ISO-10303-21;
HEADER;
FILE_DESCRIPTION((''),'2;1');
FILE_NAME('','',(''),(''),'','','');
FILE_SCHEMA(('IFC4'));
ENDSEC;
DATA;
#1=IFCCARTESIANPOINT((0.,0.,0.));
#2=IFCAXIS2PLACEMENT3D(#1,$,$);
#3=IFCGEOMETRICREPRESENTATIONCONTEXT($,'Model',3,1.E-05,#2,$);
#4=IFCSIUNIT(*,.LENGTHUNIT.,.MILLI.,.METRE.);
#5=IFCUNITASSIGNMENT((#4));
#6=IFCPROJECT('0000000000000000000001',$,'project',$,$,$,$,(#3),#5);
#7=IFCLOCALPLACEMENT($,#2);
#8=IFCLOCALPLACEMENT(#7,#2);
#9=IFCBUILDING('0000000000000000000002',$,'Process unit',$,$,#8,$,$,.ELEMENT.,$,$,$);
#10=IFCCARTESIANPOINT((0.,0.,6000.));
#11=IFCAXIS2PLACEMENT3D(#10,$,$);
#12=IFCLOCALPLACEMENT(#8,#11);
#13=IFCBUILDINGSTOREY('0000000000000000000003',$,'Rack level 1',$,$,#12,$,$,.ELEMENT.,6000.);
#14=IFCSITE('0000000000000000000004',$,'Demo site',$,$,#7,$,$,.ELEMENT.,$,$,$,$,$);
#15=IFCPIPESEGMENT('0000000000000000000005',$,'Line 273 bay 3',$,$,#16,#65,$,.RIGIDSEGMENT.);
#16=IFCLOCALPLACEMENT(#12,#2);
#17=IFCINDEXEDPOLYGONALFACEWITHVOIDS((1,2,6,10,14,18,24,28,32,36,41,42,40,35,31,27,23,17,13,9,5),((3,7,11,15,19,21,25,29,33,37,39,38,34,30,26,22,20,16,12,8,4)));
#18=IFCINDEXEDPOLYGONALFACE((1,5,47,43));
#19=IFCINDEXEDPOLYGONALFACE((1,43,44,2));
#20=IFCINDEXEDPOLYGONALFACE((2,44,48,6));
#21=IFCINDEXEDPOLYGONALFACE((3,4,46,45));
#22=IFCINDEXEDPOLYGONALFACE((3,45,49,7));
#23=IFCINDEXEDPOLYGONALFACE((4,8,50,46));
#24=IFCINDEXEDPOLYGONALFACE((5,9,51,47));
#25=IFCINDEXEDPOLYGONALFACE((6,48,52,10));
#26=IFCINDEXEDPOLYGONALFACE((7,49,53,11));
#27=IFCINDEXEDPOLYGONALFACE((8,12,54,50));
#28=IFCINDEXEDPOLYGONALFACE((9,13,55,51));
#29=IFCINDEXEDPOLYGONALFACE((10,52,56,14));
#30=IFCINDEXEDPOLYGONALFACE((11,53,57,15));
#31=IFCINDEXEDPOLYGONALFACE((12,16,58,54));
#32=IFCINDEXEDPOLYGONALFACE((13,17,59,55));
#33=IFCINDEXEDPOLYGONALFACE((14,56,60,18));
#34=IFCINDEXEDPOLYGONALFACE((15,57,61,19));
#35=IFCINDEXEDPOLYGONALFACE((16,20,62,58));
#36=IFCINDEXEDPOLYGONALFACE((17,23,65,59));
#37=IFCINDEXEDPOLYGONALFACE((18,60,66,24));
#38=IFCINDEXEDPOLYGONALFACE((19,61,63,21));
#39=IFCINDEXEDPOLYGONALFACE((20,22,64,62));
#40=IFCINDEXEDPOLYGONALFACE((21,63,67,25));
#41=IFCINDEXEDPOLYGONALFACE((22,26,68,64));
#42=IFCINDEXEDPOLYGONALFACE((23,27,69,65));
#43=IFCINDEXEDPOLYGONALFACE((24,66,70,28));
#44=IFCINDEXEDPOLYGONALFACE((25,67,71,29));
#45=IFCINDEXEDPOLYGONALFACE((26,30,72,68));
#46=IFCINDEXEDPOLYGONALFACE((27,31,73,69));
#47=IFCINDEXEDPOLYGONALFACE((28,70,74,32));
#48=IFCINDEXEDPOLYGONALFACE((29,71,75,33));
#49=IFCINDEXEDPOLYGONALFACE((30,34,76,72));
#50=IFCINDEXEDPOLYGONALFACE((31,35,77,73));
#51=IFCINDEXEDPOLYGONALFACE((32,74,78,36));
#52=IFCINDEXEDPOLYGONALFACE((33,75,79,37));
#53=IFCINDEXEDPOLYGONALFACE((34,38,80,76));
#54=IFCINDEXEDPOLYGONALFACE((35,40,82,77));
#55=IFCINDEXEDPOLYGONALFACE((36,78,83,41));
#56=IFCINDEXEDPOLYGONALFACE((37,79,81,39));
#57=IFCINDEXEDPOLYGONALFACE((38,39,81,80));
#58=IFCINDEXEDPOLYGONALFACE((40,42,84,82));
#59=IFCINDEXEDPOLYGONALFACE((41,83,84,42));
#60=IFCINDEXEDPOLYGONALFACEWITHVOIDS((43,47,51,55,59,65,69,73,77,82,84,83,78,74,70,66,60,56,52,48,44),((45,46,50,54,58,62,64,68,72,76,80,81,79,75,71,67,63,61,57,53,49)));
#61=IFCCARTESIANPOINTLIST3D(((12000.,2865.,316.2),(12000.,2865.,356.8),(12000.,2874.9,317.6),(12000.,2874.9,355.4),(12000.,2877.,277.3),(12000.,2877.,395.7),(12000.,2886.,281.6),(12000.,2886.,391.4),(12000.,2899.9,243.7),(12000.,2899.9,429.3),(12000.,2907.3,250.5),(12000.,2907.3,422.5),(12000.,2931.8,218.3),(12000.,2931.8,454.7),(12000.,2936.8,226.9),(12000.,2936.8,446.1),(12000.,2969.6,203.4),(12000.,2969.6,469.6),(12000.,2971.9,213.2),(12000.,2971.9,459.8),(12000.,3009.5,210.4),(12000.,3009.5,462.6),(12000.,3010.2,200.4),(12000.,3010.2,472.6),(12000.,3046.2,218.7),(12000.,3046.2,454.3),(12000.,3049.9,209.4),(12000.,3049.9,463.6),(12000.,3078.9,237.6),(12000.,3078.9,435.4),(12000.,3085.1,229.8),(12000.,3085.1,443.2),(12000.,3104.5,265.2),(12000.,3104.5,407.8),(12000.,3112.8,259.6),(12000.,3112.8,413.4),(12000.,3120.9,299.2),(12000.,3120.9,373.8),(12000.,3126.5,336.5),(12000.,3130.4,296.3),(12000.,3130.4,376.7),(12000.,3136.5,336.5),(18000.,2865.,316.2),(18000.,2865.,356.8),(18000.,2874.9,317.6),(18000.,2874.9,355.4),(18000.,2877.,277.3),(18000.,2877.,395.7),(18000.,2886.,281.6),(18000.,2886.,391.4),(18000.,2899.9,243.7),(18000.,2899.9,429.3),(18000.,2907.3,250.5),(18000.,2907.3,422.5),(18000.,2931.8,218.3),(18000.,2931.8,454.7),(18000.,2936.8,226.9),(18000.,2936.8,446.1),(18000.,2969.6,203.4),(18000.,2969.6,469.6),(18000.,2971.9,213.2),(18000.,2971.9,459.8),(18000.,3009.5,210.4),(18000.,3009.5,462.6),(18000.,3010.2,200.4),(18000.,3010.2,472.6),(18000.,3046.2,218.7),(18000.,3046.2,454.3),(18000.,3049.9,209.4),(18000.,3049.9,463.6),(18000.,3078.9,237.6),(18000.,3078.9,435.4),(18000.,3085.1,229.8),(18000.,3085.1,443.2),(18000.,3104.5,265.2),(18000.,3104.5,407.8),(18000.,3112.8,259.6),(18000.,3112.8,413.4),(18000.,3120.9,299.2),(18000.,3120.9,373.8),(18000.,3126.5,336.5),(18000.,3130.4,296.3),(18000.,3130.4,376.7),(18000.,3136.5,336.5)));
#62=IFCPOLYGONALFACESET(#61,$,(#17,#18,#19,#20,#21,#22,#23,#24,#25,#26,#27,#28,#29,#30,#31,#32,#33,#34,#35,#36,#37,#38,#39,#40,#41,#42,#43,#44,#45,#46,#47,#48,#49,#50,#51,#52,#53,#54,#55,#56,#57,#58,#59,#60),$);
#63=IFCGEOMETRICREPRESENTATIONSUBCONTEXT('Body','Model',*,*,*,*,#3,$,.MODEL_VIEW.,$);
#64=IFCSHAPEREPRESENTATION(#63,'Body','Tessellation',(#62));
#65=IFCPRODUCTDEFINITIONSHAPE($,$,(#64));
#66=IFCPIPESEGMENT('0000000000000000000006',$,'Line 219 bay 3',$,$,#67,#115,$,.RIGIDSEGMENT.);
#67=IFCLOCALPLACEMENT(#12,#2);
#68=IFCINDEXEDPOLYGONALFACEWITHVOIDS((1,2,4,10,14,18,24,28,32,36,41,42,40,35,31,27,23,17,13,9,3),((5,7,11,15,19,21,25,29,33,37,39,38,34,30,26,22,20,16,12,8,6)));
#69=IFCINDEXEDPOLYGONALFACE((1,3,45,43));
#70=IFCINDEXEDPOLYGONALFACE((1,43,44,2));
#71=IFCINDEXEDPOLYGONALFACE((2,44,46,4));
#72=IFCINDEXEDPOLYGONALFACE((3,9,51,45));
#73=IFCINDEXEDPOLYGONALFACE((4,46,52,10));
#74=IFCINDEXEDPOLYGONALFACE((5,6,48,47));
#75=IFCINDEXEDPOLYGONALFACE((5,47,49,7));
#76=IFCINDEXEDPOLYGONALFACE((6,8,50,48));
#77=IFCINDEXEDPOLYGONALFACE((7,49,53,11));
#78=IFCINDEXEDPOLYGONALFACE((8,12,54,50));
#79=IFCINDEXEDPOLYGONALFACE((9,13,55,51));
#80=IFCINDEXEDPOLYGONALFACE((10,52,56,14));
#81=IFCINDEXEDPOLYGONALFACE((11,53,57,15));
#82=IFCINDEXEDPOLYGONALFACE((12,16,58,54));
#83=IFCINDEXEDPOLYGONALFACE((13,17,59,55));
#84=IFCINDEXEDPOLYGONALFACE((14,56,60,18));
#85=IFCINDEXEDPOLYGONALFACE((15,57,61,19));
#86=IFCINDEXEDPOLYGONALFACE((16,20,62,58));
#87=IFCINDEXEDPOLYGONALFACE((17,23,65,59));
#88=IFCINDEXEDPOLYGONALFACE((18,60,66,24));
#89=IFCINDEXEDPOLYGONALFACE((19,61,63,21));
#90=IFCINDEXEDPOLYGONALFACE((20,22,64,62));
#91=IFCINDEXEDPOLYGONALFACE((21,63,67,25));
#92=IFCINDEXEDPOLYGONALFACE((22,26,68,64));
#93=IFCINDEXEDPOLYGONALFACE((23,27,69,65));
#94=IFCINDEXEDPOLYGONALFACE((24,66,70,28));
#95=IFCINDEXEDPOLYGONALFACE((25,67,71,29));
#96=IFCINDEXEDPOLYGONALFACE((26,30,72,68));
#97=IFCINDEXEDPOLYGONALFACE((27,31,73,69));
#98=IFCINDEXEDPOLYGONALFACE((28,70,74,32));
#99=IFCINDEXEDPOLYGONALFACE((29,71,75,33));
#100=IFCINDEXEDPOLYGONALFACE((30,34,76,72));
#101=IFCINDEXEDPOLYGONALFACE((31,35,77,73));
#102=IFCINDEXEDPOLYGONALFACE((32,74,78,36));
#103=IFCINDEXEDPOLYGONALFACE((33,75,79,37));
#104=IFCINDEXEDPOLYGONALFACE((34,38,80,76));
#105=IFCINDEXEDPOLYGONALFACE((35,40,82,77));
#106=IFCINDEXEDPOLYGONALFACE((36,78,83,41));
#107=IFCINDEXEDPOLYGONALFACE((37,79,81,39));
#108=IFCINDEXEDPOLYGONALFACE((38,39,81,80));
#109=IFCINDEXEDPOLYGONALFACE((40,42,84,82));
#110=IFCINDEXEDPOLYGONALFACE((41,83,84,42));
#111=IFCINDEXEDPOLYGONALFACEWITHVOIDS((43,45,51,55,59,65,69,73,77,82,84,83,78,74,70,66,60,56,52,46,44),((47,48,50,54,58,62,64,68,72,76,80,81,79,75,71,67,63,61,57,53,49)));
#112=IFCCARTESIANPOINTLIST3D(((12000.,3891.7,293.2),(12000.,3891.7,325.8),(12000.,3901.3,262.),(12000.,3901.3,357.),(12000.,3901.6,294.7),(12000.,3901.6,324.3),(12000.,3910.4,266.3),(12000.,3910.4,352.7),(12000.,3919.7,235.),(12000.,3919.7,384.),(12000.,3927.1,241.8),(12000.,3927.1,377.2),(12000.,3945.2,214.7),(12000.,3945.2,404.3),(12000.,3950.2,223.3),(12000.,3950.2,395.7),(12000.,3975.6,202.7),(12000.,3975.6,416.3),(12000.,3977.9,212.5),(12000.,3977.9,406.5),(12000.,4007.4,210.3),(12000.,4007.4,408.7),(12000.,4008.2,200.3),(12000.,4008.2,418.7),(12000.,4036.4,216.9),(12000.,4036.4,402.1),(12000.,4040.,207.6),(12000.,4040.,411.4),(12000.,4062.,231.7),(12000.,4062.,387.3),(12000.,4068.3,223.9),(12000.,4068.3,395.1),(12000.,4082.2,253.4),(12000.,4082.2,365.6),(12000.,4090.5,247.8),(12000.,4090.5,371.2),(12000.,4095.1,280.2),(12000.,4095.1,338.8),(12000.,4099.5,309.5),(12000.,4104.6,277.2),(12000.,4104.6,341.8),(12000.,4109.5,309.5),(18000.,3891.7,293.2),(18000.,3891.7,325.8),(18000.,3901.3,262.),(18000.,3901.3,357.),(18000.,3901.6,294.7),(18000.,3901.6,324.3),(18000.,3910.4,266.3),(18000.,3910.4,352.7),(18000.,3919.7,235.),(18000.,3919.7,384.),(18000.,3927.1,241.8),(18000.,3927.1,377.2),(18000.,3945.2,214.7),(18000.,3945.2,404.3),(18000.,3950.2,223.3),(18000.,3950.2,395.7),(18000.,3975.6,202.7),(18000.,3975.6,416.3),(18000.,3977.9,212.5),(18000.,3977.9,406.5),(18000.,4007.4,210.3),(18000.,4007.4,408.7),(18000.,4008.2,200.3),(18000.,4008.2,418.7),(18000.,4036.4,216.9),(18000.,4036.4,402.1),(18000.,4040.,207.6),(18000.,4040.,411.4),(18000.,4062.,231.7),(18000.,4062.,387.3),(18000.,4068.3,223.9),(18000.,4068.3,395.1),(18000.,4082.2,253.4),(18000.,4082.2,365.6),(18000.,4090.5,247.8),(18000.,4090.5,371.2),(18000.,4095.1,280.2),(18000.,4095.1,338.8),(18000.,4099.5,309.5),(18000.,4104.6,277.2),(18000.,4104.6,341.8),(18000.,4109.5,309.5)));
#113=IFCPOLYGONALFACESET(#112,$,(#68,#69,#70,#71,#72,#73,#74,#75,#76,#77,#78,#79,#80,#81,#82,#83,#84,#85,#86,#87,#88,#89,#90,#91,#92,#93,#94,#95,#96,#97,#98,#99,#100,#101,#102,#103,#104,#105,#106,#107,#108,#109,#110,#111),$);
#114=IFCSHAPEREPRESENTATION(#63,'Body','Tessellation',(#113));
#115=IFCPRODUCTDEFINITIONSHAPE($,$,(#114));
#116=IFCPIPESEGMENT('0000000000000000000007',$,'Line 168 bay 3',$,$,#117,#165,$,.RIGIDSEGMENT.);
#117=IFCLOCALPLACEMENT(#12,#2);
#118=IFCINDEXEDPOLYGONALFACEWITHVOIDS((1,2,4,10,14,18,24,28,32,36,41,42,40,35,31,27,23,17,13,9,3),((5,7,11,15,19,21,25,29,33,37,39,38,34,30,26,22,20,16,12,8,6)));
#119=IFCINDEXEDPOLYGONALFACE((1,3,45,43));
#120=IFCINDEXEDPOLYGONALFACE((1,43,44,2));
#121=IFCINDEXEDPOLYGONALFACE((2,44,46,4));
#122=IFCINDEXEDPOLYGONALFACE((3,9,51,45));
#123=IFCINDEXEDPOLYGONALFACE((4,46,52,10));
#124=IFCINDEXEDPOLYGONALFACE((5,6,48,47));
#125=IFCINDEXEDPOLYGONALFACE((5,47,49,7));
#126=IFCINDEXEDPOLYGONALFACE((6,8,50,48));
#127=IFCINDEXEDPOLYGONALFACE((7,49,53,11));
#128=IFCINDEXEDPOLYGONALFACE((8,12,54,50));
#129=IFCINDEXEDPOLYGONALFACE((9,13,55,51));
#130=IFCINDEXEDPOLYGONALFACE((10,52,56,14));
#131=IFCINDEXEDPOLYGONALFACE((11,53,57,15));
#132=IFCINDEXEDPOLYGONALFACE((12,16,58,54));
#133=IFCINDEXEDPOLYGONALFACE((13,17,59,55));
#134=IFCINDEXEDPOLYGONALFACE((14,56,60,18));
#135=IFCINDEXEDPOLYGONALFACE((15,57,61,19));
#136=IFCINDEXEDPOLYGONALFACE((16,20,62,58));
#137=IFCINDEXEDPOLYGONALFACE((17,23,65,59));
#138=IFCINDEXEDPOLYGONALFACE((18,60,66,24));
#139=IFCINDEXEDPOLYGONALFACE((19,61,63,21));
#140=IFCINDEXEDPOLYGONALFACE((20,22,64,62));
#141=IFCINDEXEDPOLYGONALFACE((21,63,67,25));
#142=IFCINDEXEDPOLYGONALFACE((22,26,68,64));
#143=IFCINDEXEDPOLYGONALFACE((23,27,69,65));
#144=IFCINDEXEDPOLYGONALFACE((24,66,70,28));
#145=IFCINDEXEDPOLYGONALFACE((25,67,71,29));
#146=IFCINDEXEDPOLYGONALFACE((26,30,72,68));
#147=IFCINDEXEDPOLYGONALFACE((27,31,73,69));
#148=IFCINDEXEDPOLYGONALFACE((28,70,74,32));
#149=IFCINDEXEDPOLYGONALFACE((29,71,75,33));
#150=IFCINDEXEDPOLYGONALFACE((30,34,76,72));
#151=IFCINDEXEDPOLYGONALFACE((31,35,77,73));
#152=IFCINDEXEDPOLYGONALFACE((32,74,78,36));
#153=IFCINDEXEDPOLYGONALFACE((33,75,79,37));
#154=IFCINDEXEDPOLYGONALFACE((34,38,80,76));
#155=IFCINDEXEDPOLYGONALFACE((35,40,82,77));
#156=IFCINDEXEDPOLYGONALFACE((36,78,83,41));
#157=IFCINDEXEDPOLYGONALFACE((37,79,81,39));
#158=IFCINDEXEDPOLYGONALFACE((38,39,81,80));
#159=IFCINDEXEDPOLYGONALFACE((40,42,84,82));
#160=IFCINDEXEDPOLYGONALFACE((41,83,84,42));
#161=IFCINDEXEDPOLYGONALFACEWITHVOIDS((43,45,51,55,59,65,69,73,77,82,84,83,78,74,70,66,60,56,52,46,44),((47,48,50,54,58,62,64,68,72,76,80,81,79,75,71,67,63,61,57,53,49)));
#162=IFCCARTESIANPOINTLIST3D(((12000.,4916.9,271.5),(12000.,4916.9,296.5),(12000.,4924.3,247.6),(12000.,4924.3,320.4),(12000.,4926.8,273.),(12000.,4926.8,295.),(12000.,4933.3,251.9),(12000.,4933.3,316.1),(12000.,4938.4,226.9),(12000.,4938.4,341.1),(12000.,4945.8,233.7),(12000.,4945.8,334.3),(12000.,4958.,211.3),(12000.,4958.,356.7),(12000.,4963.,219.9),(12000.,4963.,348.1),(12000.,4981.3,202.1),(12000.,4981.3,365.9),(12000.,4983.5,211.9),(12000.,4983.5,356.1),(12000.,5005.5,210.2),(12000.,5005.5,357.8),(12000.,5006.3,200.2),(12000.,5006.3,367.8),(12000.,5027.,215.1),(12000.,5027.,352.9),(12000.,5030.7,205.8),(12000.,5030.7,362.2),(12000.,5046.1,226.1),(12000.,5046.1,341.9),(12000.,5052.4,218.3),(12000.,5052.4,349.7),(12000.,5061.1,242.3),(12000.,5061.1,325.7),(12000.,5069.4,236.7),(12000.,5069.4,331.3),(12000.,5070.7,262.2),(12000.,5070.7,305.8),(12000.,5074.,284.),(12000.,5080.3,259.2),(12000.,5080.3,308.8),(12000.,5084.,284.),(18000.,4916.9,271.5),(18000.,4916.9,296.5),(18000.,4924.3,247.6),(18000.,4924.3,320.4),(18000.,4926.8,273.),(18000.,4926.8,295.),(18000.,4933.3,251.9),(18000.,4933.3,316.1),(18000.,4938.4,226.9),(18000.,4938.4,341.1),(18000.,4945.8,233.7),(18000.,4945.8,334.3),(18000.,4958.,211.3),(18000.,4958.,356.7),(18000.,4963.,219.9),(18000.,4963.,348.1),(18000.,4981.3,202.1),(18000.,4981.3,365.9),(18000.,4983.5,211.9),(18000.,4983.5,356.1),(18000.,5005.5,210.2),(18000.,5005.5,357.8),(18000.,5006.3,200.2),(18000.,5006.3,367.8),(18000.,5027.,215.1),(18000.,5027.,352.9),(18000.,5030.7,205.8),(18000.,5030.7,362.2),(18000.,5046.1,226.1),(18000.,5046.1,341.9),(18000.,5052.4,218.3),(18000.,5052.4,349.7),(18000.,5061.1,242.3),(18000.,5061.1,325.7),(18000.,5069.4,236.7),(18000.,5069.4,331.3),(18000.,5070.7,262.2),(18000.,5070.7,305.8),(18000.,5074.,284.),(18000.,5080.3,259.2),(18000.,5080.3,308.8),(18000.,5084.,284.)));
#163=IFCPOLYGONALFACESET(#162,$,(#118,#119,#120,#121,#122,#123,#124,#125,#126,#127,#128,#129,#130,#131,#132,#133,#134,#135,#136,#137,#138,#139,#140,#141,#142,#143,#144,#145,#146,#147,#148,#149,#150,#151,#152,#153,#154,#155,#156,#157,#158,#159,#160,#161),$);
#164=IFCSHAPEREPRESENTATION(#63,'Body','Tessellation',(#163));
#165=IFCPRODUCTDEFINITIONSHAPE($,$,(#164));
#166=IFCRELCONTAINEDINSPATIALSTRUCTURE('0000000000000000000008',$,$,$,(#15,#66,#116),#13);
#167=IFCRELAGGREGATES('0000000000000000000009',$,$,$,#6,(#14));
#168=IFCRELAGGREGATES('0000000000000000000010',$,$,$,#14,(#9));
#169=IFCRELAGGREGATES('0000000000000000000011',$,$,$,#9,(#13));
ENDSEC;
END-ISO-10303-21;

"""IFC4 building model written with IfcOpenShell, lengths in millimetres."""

from ifc_helpers import new_model, si_unit, frame, origin, place, context, subcontext, project, spatial, hollow_circle, extrude, element, save


model = new_model("IFC4")

# Units and contexts
model_context = context("Model", 3, precision=1e-05, world=origin())
body_context = subcontext(model_context, "Body", "Model", "MODEL_VIEW")
ifc_project = project(units=[si_unit("LENGTHUNIT", "METRE", prefix="MILLI")], contexts=[model_context])

# Site, building, storey
site_placement = place(None, origin())
site = spatial("IfcSite", under=ifc_project, at=site_placement, Name="Demo site", CompositionType="ELEMENT")
building_placement = place(site_placement, origin())
building = spatial("IfcBuilding", under=site, at=building_placement, Name="Process unit", CompositionType="ELEMENT")
storey_placement = place(building_placement, frame((0.0, 0.0, 6000.0)))
storey = spatial("IfcBuildingStorey", under=building, at=storey_placement, Name="Rack level 1", CompositionType="ELEMENT", Elevation=6000.0)

# Pipe segments
pipe_segment_1_placement = place(storey_placement, frame((12000.0, 3000.0, 336.5)))
element("IfcPipeSegment", 1, at=pipe_segment_1_placement, inside=storey, Name="Line 273 bay 3", PredefinedType="RIGIDSEGMENT", context=body_context, shape_type="SweptSolid", body=[
    extrude(hollow_circle(Radius=136.5, WallThickness=10.0), frame((0.0, 0.0, 0.0), z_axis=(1.0, 0.0, 0.0), x_axis=(0.0, 1.0, 0.0)), (0.0, 0.0, 1.0), 6000.0),
])
pipe_segment_2_placement = place(storey_placement, frame((12000.0, 4000.0, 309.5)))
element("IfcPipeSegment", 2, at=pipe_segment_2_placement, inside=storey, Name="Line 219 bay 3", PredefinedType="RIGIDSEGMENT", context=body_context, shape_type="SweptSolid", body=[
    extrude(hollow_circle(Radius=109.5, WallThickness=10.0), frame((0.0, 0.0, 0.0), z_axis=(1.0, 0.0, 0.0), x_axis=(0.0, 1.0, 0.0)), (0.0, 0.0, 1.0), 6000.0),
])
pipe_segment_3_placement = place(storey_placement, frame((12000.0, 5000.0, 284.0)))
element("IfcPipeSegment", 3, at=pipe_segment_3_placement, inside=storey, Name="Line 168 bay 3", PredefinedType="RIGIDSEGMENT", context=body_context, shape_type="SweptSolid", body=[
    extrude(hollow_circle(Radius=84.0, WallThickness=10.0), frame((0.0, 0.0, 0.0), z_axis=(1.0, 0.0, 0.0), x_axis=(0.0, 1.0, 0.0)), (0.0, 0.0, 1.0), 6000.0),
])

save(model, "model.ifc")
